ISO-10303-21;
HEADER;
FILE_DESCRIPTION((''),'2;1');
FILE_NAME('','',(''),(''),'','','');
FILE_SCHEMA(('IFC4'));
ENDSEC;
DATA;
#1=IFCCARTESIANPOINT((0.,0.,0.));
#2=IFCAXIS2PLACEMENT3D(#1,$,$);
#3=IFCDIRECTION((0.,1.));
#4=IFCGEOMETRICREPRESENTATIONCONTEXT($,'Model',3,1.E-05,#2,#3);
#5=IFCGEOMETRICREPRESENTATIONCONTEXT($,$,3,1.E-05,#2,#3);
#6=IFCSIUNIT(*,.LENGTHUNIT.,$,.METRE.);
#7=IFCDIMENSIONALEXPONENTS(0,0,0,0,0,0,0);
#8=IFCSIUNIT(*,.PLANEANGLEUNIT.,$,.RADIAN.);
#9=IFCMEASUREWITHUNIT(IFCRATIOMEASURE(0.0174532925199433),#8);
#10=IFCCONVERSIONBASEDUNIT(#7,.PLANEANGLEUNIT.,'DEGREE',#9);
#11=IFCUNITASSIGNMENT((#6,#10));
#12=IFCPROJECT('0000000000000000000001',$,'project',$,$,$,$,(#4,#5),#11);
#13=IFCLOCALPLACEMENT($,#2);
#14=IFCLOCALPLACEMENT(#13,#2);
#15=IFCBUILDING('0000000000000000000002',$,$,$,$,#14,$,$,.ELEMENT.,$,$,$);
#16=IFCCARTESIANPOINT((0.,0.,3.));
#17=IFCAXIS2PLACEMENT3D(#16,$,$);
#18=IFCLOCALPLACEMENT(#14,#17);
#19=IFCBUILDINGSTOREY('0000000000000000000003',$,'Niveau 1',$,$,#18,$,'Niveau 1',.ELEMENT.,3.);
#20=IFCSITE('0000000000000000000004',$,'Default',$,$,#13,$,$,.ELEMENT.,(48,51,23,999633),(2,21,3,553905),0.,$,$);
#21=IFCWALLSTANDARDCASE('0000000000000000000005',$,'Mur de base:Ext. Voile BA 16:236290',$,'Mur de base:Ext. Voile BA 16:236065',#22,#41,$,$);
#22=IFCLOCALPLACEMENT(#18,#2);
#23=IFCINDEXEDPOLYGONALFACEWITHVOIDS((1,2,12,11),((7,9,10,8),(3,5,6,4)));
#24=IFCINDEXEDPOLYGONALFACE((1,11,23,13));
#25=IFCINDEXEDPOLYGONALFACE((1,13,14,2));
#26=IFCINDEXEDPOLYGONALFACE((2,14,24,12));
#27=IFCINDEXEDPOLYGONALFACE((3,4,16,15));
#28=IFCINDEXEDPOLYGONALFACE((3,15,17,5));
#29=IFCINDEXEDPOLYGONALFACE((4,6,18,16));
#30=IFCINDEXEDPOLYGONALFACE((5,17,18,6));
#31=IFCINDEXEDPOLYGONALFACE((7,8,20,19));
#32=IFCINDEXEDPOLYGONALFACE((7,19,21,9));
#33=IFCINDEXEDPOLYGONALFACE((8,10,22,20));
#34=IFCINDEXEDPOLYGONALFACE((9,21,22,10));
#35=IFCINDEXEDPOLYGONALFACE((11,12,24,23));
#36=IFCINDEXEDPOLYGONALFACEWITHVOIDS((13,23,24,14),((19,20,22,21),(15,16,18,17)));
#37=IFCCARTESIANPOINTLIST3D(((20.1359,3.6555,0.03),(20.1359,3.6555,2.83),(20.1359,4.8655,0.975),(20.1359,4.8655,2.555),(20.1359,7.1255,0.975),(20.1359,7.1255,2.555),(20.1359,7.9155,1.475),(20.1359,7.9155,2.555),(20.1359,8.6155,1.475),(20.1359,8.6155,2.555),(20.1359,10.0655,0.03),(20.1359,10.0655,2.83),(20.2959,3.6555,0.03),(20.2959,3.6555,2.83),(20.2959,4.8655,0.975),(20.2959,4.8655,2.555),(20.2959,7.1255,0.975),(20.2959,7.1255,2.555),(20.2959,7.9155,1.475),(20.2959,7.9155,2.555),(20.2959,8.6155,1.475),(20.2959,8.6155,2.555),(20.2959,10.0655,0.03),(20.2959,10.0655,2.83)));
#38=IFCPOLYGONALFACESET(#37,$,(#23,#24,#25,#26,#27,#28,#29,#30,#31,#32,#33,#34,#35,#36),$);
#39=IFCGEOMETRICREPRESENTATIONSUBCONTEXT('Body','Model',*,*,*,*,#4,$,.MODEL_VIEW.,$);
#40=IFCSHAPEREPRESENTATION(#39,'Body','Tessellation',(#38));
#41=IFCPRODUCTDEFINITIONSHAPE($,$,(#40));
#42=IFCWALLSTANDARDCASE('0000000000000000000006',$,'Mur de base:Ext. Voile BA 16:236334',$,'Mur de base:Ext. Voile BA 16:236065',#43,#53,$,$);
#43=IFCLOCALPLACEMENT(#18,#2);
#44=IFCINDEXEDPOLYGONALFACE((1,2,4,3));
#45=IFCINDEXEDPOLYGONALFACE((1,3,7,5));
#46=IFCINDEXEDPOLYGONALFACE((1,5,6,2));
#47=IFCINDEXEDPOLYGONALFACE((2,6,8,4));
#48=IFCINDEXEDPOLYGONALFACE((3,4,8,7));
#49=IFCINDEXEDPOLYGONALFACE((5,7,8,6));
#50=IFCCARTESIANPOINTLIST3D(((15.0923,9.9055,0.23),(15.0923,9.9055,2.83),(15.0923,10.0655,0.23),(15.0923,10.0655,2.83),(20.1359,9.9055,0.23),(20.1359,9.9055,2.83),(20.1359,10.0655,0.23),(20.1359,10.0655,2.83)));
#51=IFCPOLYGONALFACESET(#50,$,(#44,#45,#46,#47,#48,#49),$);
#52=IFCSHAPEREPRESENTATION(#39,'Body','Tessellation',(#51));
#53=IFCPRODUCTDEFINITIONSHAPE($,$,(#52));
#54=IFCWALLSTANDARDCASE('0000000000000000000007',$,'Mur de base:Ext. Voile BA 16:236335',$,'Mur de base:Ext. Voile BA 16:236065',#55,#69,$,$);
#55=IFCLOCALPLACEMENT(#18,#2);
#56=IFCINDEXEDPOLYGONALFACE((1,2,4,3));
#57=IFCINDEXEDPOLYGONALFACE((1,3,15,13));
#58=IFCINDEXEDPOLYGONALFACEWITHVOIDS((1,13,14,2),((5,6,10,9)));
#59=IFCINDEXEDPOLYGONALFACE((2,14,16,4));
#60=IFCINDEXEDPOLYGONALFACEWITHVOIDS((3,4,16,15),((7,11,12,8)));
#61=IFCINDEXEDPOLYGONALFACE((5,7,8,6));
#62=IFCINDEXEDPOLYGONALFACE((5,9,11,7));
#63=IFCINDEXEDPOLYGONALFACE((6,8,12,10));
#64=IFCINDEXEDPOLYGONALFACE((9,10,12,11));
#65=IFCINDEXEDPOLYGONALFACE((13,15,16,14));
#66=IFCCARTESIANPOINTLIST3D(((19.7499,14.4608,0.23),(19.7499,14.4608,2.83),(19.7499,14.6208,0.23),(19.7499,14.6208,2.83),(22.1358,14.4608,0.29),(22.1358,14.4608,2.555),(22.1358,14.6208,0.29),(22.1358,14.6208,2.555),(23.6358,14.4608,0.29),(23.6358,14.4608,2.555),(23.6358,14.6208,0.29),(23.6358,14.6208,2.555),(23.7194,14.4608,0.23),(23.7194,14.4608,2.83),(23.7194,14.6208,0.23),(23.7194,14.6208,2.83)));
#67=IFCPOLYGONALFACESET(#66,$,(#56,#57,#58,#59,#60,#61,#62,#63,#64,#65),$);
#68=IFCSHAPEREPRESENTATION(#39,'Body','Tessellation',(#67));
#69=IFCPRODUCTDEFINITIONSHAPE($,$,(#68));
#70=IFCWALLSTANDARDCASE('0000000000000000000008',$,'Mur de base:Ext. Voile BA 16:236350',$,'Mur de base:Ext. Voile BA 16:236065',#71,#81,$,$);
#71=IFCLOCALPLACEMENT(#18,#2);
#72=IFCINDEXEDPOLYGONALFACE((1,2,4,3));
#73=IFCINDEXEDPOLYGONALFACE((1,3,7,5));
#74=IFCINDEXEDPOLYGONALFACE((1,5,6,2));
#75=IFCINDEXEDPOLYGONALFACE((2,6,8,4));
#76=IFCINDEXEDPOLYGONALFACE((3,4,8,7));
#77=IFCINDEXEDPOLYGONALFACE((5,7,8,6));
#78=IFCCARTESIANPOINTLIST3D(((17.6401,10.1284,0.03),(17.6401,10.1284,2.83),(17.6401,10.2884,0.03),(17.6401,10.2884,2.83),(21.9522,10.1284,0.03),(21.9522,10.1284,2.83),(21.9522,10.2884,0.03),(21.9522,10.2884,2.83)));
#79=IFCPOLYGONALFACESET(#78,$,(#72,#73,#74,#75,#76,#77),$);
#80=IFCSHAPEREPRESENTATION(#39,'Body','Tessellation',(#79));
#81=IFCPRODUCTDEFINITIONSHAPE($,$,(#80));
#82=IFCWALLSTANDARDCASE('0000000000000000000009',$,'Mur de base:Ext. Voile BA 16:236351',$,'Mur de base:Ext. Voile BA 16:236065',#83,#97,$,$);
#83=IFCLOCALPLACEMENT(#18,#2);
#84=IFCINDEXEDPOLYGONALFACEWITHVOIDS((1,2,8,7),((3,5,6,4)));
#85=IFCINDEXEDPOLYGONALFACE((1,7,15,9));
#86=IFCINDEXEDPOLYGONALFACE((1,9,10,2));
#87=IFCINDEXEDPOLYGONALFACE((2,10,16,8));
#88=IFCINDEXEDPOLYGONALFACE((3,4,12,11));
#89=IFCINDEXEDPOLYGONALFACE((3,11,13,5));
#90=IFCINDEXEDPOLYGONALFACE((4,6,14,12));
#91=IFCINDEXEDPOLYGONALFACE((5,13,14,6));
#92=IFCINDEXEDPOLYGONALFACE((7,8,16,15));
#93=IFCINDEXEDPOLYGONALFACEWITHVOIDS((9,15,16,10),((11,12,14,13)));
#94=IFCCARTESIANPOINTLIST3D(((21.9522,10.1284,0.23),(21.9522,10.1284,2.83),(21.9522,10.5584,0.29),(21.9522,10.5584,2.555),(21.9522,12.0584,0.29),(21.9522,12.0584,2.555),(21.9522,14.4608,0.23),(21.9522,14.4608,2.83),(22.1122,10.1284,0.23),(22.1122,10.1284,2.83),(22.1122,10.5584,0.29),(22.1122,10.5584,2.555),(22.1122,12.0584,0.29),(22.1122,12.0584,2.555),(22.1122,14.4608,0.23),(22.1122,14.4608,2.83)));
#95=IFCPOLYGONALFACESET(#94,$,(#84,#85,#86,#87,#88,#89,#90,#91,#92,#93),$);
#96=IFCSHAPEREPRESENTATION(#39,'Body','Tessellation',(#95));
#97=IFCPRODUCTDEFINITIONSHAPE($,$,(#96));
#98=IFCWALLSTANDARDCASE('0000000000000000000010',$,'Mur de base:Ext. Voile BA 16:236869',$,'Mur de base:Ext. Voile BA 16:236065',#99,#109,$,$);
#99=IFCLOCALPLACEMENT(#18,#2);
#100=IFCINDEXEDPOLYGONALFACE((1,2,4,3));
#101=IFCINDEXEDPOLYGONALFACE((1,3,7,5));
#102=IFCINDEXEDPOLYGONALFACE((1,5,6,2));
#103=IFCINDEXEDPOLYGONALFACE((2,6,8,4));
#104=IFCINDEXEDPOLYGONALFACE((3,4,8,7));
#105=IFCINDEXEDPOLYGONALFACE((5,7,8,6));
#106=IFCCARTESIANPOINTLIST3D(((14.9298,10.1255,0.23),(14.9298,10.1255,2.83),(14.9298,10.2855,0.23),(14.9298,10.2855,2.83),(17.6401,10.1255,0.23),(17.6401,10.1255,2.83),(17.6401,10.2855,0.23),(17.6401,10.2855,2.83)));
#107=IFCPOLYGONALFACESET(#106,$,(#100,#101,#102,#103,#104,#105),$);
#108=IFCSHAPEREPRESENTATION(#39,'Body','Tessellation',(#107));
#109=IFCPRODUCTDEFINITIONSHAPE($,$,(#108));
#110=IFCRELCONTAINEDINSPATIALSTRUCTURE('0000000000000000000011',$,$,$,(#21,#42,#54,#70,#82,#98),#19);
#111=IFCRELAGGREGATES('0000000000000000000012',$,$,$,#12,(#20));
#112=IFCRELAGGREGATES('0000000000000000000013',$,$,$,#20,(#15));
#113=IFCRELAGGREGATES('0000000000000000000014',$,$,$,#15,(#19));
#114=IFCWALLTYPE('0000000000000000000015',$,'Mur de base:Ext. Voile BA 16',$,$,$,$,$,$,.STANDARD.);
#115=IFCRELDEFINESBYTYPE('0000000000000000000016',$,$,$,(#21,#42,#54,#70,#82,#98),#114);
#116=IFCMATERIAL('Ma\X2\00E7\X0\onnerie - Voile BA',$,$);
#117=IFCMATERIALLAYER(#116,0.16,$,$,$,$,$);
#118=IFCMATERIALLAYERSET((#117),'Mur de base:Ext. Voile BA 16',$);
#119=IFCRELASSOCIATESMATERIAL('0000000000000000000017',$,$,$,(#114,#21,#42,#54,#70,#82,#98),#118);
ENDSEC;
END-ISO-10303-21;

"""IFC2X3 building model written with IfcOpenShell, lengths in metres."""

from ifc_helpers import new_model, entity, si_unit, converted_unit, direction, frame, frame_2d, origin, origin_2d_with_axis, place, context, subcontext, project, spatial, rectangle, extrude, material, layer, layer_set, layer_usage, type_object, element, save


model = new_model("IFC2X3")

# Units and contexts
model_context = context("Model", 3, precision=1e-05, world=origin(), true_north=direction((0.0, 1.0)))
context_of_model = context(None, 3, precision=1e-05, world=origin(), true_north=direction((0.0, 1.0)))
body_context = subcontext(model_context, "Body", "Model", "MODEL_VIEW")
ifc_project = project(units=[si_unit("LENGTHUNIT", "METRE"), converted_unit("PLANEANGLEUNIT", "DEGREE", entity("IfcRatioMeasure", 0.0174532925199433), si_unit("PLANEANGLEUNIT", "RADIAN"), dimensions=[0, 0, 0, 0, 0, 0, 0])], contexts=[model_context, context_of_model])

# Site, building, storey
site_placement = place(None, origin())
site = spatial("IfcSite", under=ifc_project, at=site_placement, Name="Default", CompositionType="ELEMENT", RefLatitude=(48, 51, 23, 999633), RefLongitude=(2, 21, 3, 553905), RefElevation=0.0)
building_placement = place(site_placement, origin())
building = spatial("IfcBuilding", under=site, at=building_placement, CompositionType="ELEMENT")
storey_placement = place(building_placement, frame((0.0, 0.0, 3.0)))
storey = spatial("IfcBuildingStorey", under=building, at=storey_placement, Name="Niveau 1", LongName="Niveau 1", CompositionType="ELEMENT", Elevation=3.0)

# Shared definitions
ifc_material_1 = material(Name="Maçonnerie - Voile BA")

# Wall, openings
ifc_layer_1 = layer(ifc_material_1, 0.16)
ifc_layer_set_1 = layer_set([ifc_layer_1], Name="Mur de base:Ext. Voile BA 16")
wall_type_1 = type_object("IfcWallType", Name="Mur de base:Ext. Voile BA 16", PredefinedType="STANDARD", material=ifc_layer_set_1)
ifc_layer_usage_1 = layer_usage(ifc_layer_set_1, "AXIS2", "NEGATIVE", 0.08)
wall_1_placement = place(storey_placement, frame((20.2159, 10.0655, 0.03), z_axis=(0.0, 0.0, 1.0), x_axis=(0.0, -1.0, 0.0)))
wall_1 = element("IfcWallStandardCase", 1, at=wall_1_placement, inside=storey, type_object=wall_type_1, material=ifc_layer_usage_1, Name="Mur de base:Ext. Voile BA 16:236290", ObjectType="Mur de base:Ext. Voile BA 16:236065", context=body_context, shape_type="SweptSolid", body=[
    extrude(rectangle(XDim=6.41, YDim=0.16, at=frame_2d((3.205, 0.0), x_axis=(-1.0, 0.0))), origin(), (0.0, 0.0, 1.0), 2.8),
])
opening_1_placement = place(wall_1_placement, origin())
element("IfcOpeningElement", 2, at=opening_1_placement, cuts=wall_1, ObjectType="Opening", context=body_context, shape_type="SweptSolid", body=[
    extrude(rectangle(XDim=1.58, YDim=2.26, at=origin_2d_with_axis()), frame((4.07, -0.08, 1.735), z_axis=(0.0, 1.0, 0.0), x_axis=(0.0, 0.0, -1.0)), (0.0, 0.0, 1.0), 0.16),
])
opening_2_placement = place(wall_1_placement, origin())
element("IfcOpeningElement", 3, at=opening_2_placement, cuts=wall_1, ObjectType="Opening", context=body_context, shape_type="SweptSolid", body=[
    extrude(rectangle(XDim=1.08, YDim=0.7, at=origin_2d_with_axis()), frame((1.8, -0.08, 1.985), z_axis=(0.0, 1.0, 0.0), x_axis=(0.0, 0.0, -1.0)), (0.0, 0.0, 1.0), 0.16),
])

# Wall
ifc_layer_usage_2 = layer_usage(ifc_layer_set_1, "AXIS2", "NEGATIVE", 0.08)
wall_2_placement = place(storey_placement, frame((15.0923, 9.9855, 0.23)))
element("IfcWallStandardCase", 4, at=wall_2_placement, inside=storey, type_object=wall_type_1, material=ifc_layer_usage_2, Name="Mur de base:Ext. Voile BA 16:236334", ObjectType="Mur de base:Ext. Voile BA 16:236065", context=body_context, shape_type="SweptSolid", body=[
    extrude(rectangle(XDim=5.0437, YDim=0.16, at=frame_2d((2.5218, 0.0), x_axis=(-1.0, 0.0))), origin(), (0.0, 0.0, 1.0), 2.6),
])

# Wall, opening
ifc_layer_usage_3 = layer_usage(ifc_layer_set_1, "AXIS2", "NEGATIVE", 0.08)
wall_3_placement = place(storey_placement, frame((23.7194, 14.5408, 0.23), z_axis=(0.0, 0.0, 1.0), x_axis=(-1.0, 0.0, 0.0)))
wall_3 = element("IfcWallStandardCase", 5, at=wall_3_placement, inside=storey, type_object=wall_type_1, material=ifc_layer_usage_3, Name="Mur de base:Ext. Voile BA 16:236335", ObjectType="Mur de base:Ext. Voile BA 16:236065", context=body_context, shape_type="SweptSolid", body=[
    extrude(rectangle(XDim=3.9695, YDim=0.16, at=frame_2d((1.9848, 0.0), x_axis=(-1.0, 0.0))), origin(), (0.0, 0.0, 1.0), 2.6),
])
opening_3_placement = place(wall_3_placement, origin())
element("IfcOpeningElement", 6, at=opening_3_placement, cuts=wall_3, ObjectType="Opening", context=body_context, shape_type="SweptSolid", body=[
    extrude(rectangle(XDim=2.265, YDim=1.5, at=origin_2d_with_axis()), frame((0.8336, -0.08, 1.1925), z_axis=(0.0, 1.0, 0.0), x_axis=(0.0, 0.0, -1.0)), (0.0, 0.0, 1.0), 0.16),
])

# Wall
ifc_layer_usage_4 = layer_usage(ifc_layer_set_1, "AXIS2", "NEGATIVE", 0.08)
wall_4_placement = place(storey_placement, frame((21.9522, 10.2084, 0.03), z_axis=(0.0, 0.0, 1.0), x_axis=(-1.0, 0.0, 0.0)))
element("IfcWallStandardCase", 7, at=wall_4_placement, inside=storey, type_object=wall_type_1, material=ifc_layer_usage_4, Name="Mur de base:Ext. Voile BA 16:236350", ObjectType="Mur de base:Ext. Voile BA 16:236065", context=body_context, shape_type="SweptSolid", body=[
    extrude(rectangle(XDim=4.3121, YDim=0.16, at=frame_2d((2.1561, 0.0), x_axis=(-1.0, 0.0))), origin(), (0.0, 0.0, 1.0), 2.8),
])

# Wall, opening
ifc_layer_usage_5 = layer_usage(ifc_layer_set_1, "AXIS2", "NEGATIVE", 0.08)
wall_5_placement = place(storey_placement, frame((22.0322, 14.4608, 0.23), z_axis=(0.0, 0.0, 1.0), x_axis=(0.0, -1.0, 0.0)))
wall_5 = element("IfcWallStandardCase", 8, at=wall_5_placement, inside=storey, type_object=wall_type_1, material=ifc_layer_usage_5, Name="Mur de base:Ext. Voile BA 16:236351", ObjectType="Mur de base:Ext. Voile BA 16:236065", context=body_context, shape_type="SweptSolid", body=[
    extrude(rectangle(XDim=4.3324, YDim=0.16, at=frame_2d((2.1662, 0.0), x_axis=(-1.0, 0.0))), origin(), (0.0, 0.0, 1.0), 2.6),
])
opening_4_placement = place(wall_5_placement, origin())
element("IfcOpeningElement", 9, at=opening_4_placement, cuts=wall_5, ObjectType="Opening", context=body_context, shape_type="SweptSolid", body=[
    extrude(rectangle(XDim=2.265, YDim=1.5, at=origin_2d_with_axis()), frame((3.1524, -0.08, 1.1925), z_axis=(0.0, 1.0, 0.0), x_axis=(0.0, 0.0, -1.0)), (0.0, 0.0, 1.0), 0.16),
])

# Wall
ifc_layer_usage_6 = layer_usage(ifc_layer_set_1, "AXIS2", "NEGATIVE", 0.08)
wall_6_placement = place(storey_placement, frame((14.9298, 10.2055, 0.23)))
element("IfcWallStandardCase", 10, at=wall_6_placement, inside=storey, type_object=wall_type_1, material=ifc_layer_usage_6, Name="Mur de base:Ext. Voile BA 16:236869", ObjectType="Mur de base:Ext. Voile BA 16:236065", context=body_context, shape_type="SweptSolid", body=[
    extrude(rectangle(XDim=2.7103, YDim=0.16, at=frame_2d((1.3552, 0.0), x_axis=(-1.0, 0.0))), origin(), (0.0, 0.0, 1.0), 2.6),
])

save(model, "model.ifc")
